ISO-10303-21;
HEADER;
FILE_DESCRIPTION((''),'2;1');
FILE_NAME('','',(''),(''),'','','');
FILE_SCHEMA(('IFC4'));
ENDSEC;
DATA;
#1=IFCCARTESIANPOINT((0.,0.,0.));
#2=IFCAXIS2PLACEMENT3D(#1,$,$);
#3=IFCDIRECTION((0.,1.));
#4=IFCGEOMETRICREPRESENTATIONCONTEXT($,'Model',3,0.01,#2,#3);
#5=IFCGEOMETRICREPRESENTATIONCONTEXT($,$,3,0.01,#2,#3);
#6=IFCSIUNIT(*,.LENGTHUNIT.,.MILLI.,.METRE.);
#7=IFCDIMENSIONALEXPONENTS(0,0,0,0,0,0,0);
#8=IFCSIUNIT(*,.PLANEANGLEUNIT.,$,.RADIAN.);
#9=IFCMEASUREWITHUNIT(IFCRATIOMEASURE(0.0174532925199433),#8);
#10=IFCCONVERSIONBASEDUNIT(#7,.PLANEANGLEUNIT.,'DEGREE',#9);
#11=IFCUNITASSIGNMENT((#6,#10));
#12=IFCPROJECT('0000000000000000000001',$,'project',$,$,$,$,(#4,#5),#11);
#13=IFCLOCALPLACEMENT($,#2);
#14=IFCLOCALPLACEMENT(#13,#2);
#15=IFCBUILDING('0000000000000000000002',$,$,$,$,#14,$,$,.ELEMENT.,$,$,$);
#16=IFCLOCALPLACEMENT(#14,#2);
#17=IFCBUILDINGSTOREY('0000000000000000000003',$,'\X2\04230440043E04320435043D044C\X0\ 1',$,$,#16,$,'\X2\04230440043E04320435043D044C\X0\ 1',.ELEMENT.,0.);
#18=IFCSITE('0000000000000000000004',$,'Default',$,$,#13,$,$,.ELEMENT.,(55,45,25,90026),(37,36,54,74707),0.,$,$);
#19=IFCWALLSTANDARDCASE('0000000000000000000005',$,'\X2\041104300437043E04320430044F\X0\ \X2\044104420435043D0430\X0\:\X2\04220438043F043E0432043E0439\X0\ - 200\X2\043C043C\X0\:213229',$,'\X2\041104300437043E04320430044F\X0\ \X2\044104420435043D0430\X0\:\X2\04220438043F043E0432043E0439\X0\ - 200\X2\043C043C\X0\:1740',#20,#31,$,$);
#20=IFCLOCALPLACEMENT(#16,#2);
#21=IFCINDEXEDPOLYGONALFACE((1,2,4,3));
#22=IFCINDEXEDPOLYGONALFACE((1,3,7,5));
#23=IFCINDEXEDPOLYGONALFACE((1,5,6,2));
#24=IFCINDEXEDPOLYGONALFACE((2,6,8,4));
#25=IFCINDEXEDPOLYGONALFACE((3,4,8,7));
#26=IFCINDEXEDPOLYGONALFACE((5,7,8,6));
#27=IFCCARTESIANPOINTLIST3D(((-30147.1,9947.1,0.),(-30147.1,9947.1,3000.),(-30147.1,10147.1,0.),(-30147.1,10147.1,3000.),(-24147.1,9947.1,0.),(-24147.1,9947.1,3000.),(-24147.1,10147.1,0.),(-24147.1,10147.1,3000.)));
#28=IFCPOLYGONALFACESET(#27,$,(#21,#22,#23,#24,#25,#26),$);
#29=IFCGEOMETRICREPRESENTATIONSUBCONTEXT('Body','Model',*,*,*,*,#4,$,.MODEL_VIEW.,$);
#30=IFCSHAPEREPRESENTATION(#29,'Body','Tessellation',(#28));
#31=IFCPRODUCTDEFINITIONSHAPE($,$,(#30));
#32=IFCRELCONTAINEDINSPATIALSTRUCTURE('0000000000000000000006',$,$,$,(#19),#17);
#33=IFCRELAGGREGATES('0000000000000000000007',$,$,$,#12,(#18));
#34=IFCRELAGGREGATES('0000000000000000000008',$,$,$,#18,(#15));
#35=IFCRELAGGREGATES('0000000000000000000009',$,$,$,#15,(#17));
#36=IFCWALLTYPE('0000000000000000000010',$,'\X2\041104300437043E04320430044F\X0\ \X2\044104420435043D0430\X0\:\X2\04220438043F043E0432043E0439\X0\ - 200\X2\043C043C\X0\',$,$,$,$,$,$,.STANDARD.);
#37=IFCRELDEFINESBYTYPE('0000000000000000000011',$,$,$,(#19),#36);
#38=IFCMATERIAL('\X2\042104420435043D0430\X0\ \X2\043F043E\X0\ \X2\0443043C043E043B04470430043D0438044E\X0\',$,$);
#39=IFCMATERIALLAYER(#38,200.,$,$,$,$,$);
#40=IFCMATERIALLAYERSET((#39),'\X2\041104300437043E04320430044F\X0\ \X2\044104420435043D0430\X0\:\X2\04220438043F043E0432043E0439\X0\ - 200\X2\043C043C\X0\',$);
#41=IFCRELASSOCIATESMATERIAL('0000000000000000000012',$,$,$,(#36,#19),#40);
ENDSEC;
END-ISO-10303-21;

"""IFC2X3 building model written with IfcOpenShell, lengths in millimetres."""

from ifc_helpers import new_model, entity, si_unit, converted_unit, direction, frame, frame_2d, origin, place, context, subcontext, project, spatial, rectangle, extrude, material, layer, layer_set, layer_usage, type_object, element, save


model = new_model("IFC2X3")

# Units and contexts
model_context = context("Model", 3, precision=0.01, world=origin(), true_north=direction((0.0, 1.0)))
context_of_model = context(None, 3, precision=0.01, world=origin(), true_north=direction((0.0, 1.0)))
body_context = subcontext(model_context, "Body", "Model", "MODEL_VIEW")
ifc_project = project(units=[si_unit("LENGTHUNIT", "METRE", prefix="MILLI"), converted_unit("PLANEANGLEUNIT", "DEGREE", entity("IfcRatioMeasure", 0.0174532925199433), si_unit("PLANEANGLEUNIT", "RADIAN"), dimensions=[0, 0, 0, 0, 0, 0, 0])], contexts=[model_context, context_of_model])

# Site, building, storey
site_placement = place(None, origin())
site = spatial("IfcSite", under=ifc_project, at=site_placement, Name="Default", CompositionType="ELEMENT", RefLatitude=(55, 45, 25, 90026), RefLongitude=(37, 36, 54, 74707), RefElevation=0.0)
building_placement = place(site_placement, origin())
building = spatial("IfcBuilding", under=site, at=building_placement, CompositionType="ELEMENT")
storey_placement = place(building_placement, origin())
storey = spatial("IfcBuildingStorey", under=building, at=storey_placement, Name="Уровень 1", LongName="Уровень 1", CompositionType="ELEMENT", Elevation=0.0)

# Wall
ifc_material = material(Name="Стена по умолчанию")
ifc_layer = layer(ifc_material, 200.0)
ifc_layer_set = layer_set([ifc_layer], Name="Базовая стена:Типовой - 200мм")
ifc_layer_usage = layer_usage(ifc_layer_set, "AXIS2", "NEGATIVE", 100.0)
wall_type = type_object("IfcWallType", Name="Базовая стена:Типовой - 200мм", PredefinedType="STANDARD", material=ifc_layer_set)
wall_placement = place(storey_placement, frame((-30147.1, 10047.1, 0.0)))
element("IfcWallStandardCase", 1, at=wall_placement, inside=storey, type_object=wall_type, material=ifc_layer_usage, Name="Базовая стена:Типовой - 200мм:213229", ObjectType="Базовая стена:Типовой - 200мм:1740", context=body_context, shape_type="SweptSolid", body=[
    extrude(rectangle(XDim=6000.0, YDim=200.0, at=frame_2d((3000.0, 0.0), x_axis=(-1.0, 0.0))), origin(), (0.0, 0.0, 1.0), 3000.0),
])

save(model, "model.ifc")
